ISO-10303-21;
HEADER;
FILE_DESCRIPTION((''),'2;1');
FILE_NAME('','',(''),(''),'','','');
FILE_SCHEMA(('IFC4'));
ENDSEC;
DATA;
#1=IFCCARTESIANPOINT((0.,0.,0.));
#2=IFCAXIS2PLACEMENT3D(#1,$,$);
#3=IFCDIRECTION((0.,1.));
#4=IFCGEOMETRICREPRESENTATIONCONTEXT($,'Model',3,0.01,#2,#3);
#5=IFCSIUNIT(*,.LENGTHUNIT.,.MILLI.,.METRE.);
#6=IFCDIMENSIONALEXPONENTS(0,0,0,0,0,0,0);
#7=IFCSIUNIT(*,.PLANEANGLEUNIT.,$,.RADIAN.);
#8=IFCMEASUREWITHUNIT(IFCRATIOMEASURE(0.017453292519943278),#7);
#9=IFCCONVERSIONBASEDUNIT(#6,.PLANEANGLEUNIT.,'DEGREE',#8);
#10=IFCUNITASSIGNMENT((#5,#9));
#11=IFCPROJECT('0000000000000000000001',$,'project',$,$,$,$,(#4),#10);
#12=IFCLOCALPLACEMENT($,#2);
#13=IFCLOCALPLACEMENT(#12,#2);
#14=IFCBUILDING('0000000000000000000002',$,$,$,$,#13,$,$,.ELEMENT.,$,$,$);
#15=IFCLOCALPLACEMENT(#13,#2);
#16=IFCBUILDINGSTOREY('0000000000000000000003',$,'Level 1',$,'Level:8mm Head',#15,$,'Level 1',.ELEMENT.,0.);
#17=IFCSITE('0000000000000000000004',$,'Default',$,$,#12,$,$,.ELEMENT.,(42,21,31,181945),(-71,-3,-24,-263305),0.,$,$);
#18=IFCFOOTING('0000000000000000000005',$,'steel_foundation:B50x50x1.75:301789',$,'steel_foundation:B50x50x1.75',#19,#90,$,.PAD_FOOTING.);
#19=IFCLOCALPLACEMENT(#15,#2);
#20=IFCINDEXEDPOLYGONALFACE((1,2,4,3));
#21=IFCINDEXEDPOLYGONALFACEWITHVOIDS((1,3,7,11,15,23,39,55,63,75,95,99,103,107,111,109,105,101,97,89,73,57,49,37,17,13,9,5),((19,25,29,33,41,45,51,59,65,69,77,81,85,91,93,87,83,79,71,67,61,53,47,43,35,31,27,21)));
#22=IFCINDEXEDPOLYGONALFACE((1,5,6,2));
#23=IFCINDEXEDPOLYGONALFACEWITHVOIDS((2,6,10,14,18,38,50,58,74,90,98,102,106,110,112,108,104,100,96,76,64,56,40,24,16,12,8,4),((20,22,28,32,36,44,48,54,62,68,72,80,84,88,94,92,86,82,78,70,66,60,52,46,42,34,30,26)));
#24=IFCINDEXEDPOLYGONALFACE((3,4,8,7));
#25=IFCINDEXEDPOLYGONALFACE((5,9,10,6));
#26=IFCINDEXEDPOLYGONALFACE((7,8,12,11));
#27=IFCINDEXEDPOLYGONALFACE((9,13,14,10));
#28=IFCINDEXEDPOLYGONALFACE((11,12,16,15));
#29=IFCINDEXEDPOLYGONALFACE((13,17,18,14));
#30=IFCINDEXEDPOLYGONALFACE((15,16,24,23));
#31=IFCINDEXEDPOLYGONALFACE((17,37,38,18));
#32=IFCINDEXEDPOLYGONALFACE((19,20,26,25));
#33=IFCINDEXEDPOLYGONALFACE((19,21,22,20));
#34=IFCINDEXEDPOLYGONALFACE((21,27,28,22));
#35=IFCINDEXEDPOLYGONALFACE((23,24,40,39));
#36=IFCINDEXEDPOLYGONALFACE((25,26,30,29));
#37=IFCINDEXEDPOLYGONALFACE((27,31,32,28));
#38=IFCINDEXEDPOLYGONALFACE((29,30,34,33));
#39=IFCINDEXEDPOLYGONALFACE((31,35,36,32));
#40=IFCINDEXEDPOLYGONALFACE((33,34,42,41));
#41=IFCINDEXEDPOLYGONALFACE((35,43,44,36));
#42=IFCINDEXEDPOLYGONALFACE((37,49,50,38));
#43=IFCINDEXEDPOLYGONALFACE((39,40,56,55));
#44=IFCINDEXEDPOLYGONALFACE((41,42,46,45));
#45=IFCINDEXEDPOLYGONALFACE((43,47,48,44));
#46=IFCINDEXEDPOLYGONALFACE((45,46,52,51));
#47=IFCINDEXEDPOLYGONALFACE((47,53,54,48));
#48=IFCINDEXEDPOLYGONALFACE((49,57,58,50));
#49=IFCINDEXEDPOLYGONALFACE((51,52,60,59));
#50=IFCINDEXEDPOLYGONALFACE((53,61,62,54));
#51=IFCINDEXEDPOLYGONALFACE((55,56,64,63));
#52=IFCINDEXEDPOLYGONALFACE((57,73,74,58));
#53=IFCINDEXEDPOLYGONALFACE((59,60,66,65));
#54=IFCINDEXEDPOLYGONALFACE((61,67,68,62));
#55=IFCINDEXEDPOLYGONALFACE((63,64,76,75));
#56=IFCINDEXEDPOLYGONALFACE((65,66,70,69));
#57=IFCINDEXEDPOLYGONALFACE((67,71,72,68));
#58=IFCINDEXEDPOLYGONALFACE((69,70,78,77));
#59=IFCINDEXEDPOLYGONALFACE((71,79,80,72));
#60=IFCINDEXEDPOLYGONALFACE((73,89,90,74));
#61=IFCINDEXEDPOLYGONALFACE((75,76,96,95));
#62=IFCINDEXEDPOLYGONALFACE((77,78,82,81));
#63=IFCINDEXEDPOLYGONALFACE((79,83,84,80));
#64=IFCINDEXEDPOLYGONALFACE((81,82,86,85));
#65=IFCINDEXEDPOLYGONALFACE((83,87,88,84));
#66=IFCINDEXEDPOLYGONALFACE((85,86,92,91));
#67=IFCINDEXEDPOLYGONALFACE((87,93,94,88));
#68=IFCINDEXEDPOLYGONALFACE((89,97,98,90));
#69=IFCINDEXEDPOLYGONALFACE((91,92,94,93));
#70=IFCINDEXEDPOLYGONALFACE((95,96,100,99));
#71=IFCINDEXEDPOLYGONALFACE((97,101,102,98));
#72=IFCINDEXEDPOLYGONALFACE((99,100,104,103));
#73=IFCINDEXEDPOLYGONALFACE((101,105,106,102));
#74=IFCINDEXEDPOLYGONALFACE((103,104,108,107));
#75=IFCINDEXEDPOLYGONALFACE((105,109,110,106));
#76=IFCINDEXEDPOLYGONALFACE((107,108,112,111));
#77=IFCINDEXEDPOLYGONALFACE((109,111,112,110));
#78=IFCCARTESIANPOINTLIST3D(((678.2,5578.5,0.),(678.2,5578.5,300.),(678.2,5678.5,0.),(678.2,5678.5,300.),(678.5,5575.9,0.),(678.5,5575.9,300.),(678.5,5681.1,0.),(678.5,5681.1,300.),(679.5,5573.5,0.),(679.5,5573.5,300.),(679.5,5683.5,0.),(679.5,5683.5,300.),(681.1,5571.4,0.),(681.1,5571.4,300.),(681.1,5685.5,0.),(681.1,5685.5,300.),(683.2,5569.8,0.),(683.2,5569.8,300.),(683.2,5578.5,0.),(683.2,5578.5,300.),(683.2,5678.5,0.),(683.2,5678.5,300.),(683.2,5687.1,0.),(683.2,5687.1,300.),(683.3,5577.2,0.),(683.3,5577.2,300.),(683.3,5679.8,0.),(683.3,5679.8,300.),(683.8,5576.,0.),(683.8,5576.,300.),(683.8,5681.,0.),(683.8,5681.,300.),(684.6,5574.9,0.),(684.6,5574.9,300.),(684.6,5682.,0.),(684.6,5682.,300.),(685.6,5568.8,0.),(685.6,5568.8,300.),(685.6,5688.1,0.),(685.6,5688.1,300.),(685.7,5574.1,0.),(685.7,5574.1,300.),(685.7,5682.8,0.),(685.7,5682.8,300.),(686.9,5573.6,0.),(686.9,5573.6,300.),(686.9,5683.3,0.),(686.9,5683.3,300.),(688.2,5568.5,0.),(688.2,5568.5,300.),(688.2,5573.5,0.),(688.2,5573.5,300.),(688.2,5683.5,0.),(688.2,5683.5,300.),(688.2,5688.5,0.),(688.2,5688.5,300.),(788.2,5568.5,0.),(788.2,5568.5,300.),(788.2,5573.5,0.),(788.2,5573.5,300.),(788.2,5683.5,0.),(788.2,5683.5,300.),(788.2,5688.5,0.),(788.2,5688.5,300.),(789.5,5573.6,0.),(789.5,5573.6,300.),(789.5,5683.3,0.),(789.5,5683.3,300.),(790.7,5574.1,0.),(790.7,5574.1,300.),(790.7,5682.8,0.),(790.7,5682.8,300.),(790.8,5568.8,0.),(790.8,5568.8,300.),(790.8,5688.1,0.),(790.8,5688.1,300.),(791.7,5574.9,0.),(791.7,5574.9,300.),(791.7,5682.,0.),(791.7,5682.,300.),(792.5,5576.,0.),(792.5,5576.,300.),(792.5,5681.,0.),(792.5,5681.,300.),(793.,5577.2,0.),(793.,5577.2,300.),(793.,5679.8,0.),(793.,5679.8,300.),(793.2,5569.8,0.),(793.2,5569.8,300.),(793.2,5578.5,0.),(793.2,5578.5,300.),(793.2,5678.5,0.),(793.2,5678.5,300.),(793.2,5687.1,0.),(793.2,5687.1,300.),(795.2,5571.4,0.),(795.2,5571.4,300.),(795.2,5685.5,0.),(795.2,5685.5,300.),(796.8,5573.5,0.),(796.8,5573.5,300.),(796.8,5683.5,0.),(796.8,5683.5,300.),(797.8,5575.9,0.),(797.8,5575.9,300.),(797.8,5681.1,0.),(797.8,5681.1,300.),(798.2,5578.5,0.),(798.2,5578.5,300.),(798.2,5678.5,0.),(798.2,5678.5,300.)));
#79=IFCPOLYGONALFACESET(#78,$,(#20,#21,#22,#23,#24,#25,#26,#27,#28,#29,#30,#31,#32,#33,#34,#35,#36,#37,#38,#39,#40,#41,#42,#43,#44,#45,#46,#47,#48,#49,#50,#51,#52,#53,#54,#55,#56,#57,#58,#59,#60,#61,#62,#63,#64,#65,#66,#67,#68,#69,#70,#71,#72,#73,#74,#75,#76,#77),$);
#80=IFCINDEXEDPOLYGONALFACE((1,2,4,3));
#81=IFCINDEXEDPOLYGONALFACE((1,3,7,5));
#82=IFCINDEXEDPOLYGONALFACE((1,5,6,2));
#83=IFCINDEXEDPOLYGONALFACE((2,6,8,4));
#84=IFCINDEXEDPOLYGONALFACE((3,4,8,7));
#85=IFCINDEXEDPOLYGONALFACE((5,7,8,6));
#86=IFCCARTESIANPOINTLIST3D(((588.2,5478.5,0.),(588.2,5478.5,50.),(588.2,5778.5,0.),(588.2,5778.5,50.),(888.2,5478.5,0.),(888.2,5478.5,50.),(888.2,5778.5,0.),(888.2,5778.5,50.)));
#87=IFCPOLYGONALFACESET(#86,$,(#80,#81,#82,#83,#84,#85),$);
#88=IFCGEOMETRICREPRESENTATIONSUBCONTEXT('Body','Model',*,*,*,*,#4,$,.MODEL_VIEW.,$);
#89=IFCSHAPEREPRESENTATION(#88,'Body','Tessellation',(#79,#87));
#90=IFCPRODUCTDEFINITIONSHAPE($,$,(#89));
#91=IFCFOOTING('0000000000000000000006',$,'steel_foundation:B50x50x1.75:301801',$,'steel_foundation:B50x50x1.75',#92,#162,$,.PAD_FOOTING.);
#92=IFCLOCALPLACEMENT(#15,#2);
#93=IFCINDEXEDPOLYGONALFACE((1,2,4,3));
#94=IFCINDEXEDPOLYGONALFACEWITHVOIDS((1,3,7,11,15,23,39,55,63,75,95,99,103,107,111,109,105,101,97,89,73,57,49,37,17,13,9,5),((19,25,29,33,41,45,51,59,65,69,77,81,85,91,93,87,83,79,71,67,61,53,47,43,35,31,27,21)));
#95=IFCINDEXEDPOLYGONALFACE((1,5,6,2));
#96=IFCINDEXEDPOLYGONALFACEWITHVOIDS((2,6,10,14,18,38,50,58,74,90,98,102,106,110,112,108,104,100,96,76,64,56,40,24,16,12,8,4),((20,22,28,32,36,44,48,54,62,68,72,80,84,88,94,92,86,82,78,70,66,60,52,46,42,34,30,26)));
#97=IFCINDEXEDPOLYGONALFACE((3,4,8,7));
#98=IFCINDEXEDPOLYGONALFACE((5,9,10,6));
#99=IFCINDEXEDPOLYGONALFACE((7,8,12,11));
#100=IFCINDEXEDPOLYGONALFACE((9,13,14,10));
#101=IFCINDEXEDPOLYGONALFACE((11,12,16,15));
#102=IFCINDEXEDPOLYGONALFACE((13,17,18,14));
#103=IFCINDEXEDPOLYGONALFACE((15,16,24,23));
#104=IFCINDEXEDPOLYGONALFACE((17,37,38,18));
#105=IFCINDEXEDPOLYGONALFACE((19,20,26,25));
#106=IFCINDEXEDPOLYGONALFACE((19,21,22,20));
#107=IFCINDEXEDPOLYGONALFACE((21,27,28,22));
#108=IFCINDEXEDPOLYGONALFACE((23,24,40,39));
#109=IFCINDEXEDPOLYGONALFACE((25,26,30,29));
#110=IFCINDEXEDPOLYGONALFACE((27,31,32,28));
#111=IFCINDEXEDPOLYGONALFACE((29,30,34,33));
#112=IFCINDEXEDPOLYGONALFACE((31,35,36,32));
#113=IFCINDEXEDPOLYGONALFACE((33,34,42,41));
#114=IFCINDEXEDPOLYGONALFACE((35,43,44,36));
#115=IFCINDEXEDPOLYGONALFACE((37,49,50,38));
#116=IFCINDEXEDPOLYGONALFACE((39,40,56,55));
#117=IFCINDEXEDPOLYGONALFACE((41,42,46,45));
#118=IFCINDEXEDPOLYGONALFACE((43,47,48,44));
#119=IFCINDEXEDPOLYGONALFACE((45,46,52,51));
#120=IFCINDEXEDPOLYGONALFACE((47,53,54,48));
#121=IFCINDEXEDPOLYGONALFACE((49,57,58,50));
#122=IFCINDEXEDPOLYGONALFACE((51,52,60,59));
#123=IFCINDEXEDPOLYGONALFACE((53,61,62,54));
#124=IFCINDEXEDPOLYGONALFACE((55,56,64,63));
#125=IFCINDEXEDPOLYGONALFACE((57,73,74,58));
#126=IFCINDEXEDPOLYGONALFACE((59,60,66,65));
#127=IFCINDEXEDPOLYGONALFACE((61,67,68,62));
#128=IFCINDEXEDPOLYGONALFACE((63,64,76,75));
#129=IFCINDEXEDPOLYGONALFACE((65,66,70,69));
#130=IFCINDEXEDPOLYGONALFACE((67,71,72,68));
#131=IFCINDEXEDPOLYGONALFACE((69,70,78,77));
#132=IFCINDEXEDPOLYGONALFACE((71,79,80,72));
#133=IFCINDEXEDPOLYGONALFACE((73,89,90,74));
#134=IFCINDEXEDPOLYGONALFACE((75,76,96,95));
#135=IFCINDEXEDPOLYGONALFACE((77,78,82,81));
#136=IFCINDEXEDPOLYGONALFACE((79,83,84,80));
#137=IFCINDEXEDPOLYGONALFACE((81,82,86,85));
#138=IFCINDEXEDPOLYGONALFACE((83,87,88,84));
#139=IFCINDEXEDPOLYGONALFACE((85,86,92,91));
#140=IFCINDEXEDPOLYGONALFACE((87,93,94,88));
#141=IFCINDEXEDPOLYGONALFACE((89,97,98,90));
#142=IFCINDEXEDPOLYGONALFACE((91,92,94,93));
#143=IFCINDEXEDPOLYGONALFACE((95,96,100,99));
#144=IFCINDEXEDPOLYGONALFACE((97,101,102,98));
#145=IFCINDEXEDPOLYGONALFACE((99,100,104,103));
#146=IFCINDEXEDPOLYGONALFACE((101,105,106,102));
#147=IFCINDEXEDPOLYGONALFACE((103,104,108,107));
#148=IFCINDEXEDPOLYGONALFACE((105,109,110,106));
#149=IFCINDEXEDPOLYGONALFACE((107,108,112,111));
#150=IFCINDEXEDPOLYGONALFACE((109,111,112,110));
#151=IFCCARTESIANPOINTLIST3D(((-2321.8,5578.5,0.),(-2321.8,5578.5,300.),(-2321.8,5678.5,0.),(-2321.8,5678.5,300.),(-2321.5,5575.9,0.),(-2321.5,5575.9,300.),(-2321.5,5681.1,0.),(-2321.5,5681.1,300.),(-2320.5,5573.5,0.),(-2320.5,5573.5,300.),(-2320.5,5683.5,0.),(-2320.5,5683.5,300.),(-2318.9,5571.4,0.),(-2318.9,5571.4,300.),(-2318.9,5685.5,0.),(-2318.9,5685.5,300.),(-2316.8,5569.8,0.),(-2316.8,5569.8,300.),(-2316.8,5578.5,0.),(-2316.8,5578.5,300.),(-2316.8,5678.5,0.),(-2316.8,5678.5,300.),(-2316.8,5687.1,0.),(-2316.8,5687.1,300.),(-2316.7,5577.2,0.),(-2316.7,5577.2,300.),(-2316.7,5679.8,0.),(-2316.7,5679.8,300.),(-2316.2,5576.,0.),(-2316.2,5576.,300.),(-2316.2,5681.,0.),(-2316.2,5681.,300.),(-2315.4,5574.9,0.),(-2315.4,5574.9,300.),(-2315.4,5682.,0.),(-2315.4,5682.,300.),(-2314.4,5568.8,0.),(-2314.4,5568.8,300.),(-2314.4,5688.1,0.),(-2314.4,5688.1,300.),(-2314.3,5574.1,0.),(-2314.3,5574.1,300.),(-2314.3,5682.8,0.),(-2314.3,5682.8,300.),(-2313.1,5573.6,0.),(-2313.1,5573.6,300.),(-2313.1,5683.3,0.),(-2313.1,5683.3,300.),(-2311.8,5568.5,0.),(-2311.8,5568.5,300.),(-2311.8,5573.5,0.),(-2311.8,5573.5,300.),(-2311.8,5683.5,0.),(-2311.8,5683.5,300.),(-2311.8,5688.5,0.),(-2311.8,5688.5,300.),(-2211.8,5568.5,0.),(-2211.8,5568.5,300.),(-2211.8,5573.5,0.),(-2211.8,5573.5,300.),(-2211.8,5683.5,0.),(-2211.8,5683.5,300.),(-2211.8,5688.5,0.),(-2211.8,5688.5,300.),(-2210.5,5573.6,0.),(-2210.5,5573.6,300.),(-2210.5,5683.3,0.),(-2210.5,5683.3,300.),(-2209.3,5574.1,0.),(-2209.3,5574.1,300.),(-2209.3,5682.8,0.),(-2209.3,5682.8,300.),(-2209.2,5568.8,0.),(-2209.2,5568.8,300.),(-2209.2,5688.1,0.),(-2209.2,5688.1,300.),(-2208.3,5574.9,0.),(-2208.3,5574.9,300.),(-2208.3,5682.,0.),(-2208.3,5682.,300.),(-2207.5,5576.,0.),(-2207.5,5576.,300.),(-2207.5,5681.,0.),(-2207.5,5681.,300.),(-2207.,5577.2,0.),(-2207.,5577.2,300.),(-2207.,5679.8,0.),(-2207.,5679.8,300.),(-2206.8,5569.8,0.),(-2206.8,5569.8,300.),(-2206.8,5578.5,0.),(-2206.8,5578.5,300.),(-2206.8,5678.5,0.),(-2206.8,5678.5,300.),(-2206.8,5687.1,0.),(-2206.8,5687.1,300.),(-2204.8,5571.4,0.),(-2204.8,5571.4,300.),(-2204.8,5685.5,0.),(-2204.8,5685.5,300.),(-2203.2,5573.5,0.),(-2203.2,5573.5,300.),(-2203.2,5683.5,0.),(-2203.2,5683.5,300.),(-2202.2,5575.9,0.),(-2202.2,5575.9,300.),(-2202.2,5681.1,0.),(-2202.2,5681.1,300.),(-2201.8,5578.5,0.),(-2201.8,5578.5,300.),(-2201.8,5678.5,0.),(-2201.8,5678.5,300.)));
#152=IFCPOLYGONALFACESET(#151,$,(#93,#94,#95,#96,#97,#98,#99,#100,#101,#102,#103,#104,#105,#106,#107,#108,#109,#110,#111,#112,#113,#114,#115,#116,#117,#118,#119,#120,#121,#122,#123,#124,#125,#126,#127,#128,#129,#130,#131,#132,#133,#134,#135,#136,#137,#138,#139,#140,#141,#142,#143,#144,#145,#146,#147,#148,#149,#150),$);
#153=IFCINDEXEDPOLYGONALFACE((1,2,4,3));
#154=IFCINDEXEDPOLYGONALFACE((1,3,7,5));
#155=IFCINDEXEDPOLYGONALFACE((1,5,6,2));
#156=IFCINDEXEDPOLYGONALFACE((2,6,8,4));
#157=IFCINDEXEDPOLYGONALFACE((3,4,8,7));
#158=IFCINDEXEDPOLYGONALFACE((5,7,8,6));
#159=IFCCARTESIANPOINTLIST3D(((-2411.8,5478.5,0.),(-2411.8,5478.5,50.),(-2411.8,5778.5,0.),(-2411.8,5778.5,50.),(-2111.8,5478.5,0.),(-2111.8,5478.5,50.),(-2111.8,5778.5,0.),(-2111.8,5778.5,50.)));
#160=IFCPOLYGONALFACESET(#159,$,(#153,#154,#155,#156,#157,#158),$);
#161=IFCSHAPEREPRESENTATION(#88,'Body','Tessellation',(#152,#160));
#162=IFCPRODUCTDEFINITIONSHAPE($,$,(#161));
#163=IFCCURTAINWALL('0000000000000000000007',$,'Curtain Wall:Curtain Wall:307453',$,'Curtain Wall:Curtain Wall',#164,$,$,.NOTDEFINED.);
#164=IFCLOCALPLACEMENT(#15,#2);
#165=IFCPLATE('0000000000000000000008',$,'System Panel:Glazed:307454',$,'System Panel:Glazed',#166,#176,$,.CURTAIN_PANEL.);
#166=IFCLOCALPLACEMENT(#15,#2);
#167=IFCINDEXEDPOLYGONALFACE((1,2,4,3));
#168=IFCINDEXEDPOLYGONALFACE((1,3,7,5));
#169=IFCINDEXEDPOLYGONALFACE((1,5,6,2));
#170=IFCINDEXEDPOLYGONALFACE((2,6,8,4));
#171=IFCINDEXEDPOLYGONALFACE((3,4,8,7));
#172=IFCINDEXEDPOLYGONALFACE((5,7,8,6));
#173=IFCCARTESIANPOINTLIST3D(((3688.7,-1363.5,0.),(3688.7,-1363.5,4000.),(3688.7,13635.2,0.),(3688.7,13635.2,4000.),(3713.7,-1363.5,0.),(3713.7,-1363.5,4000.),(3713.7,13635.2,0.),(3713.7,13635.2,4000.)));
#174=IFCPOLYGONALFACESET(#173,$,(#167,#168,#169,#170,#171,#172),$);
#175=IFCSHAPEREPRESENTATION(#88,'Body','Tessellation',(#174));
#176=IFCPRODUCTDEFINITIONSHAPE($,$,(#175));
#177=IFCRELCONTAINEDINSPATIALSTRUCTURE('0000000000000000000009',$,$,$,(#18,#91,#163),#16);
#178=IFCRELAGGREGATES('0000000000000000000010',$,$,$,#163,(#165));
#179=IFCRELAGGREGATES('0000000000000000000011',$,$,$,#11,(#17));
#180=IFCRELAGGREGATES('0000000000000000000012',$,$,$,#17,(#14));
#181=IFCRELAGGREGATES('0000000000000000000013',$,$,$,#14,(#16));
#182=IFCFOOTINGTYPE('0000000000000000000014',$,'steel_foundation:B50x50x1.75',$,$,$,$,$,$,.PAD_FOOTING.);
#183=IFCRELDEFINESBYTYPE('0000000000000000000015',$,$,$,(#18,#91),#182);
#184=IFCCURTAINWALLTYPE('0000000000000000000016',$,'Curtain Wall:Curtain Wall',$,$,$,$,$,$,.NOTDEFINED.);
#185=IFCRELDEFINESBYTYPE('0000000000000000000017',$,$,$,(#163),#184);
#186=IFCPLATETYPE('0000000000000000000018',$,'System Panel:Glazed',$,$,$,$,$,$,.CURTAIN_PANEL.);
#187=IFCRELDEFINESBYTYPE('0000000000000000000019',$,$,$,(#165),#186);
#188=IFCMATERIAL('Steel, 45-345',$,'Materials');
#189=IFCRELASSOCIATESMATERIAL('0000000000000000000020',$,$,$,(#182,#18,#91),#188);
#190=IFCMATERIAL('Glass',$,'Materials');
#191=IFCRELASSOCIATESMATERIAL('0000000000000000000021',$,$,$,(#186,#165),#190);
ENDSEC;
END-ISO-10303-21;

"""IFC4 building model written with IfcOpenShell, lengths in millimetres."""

from ifc_helpers import new_model, entity, si_unit, converted_unit, direction, frame, frame_2d, origin, origin_2d_with_axis, place, context, subcontext, project, spatial, polyline, circle_curve, parameter, trimmed, segment, composite_curve, rectangle, outline, extrude, source, transform, mapped, material, type_object, type_shapes, element, aggregate, save


model = new_model("IFC4")

# Units and contexts
model_context = context("Model", 3, precision=0.01, world=origin(), true_north=direction((0.0, 1.0)))
body_context = subcontext(model_context, "Body", "Model", "MODEL_VIEW")
ifc_project = project(units=[si_unit("LENGTHUNIT", "METRE", prefix="MILLI"), converted_unit("PLANEANGLEUNIT", "DEGREE", entity("IfcRatioMeasure", 0.017453292519943278), si_unit("PLANEANGLEUNIT", "RADIAN"), dimensions=[0, 0, 0, 0, 0, 0, 0])], contexts=[model_context])

# Site, building, storey
site_placement = place(None, origin())
site = spatial("IfcSite", under=ifc_project, at=site_placement, Name="Default", CompositionType="ELEMENT", RefLatitude=(42, 21, 31, 181945), RefLongitude=(-71, -3, -24, -263305), RefElevation=0.0)
building_placement = place(site_placement, origin())
building = spatial("IfcBuilding", under=site, at=building_placement, CompositionType="ELEMENT")
storey_placement = place(building_placement, origin())
storey = spatial("IfcBuildingStorey", under=building, at=storey_placement, Name="Level 1", ObjectType="Level:8mm Head", LongName="Level 1", CompositionType="ELEMENT", Elevation=0.0)

# Footings
ifc_material_1 = material(Name="Steel, 45-345", Category="Materials")
footing_type = type_object("IfcFootingType", Name="steel_foundation:B50x50x1.75", PredefinedType="PAD_FOOTING", material=ifc_material_1)
shared_shape_1 = source(origin(), body_context, "Body", "SweptSolid", [
    extrude(outline(composite_curve([segment(polyline([(-50.0, -60.0), (50.0, -60.0)]), True, "CONTINUOUS"), segment(trimmed(circle_curve(frame_2d((50.0, -50.0), x_axis=(-1.0, 0.0)), 10.0), [parameter(90.0)], [parameter(180.0)], True, "PARAMETER"), True, "CONTINUOUS"), segment(polyline([(60.0, -50.0), (60.0, 50.0)]), True, "CONTINUOUS"), segment(trimmed(circle_curve(frame_2d((50.0, 50.0), x_axis=(-1.0, 0.0)), 10.0), [parameter(180.0)], [parameter(270.0)], True, "PARAMETER"), True, "CONTINUOUS"), segment(polyline([(50.0, 60.0), (-50.0, 60.0)]), True, "CONTINUOUS"), segment(trimmed(circle_curve(frame_2d((-50.0, 50.0), x_axis=(-1.0, 0.0)), 10.0), [parameter(270.0)], [parameter(360.0)], True, "PARAMETER"), True, "CONTINUOUS"), segment(polyline([(-60.0, 50.0), (-60.0, -50.0)]), True, "CONTINUOUS"), segment(trimmed(circle_curve(frame_2d((-50.0, -50.0), x_axis=(-1.0, 0.0)), 10.0), [parameter(360.0)], [parameter(90.0)], True, "PARAMETER"), True, "CONTINUOUS")], self_intersect=False), holes=[composite_curve([segment(trimmed(circle_curve(frame_2d((-50.0, -50.0), x_axis=(-1.0, 0.0)), 5.0), [parameter(0.0)], [parameter(90.0)], True, "PARAMETER"), False, "CONTINUOUS"), segment(polyline([(-55.0, -50.0), (-55.0, 50.0)]), True, "CONTINUOUS"), segment(trimmed(circle_curve(frame_2d((-50.0, 50.0), x_axis=(-1.0, 0.0)), 5.0), [parameter(270.0)], [parameter(360.0)], True, "PARAMETER"), False, "CONTINUOUS"), segment(polyline([(-50.0, 55.0), (50.0, 55.0)]), True, "CONTINUOUS"), segment(trimmed(circle_curve(frame_2d((50.0, 50.0), x_axis=(-1.0, 0.0)), 5.0), [parameter(180.0)], [parameter(270.0)], True, "PARAMETER"), False, "CONTINUOUS"), segment(polyline([(55.0, 50.0), (55.0, -50.0)]), True, "CONTINUOUS"), segment(trimmed(circle_curve(frame_2d((50.0, -50.0), x_axis=(-1.0, 0.0)), 5.0), [parameter(90.0)], [parameter(180.0)], True, "PARAMETER"), False, "CONTINUOUS"), segment(polyline([(50.0, -55.0), (-50.0, -55.0)]), True, "CONTINUOUS")], self_intersect=False)]), frame((0.0, 0.0, 0.0), z_axis=(0.0, 0.0, 1.0), x_axis=(-1.0, 0.0, 0.0)), (0.0, 0.0, 1.0), 300.0),
    extrude(rectangle(XDim=300.0, YDim=300.0, at=frame_2d((0.0, 0.0), x_axis=(1.0, 0.0))), frame((0.0, 0.0, 0.0), z_axis=(0.0, 0.0, 1.0), x_axis=(-1.0, 0.0, 0.0)), (0.0, 0.0, 1.0), 50.0),
])
type_shapes(footing_type, [shared_shape_1])
for number, where, name in (
    (1, (738.2, 5628.5, 0.0), "steel_foundation:B50x50x1.75:301789"),
    (2, (-2261.8, 5628.5, 0.0), "steel_foundation:B50x50x1.75:301801"),
):
    element("IfcFooting", number, at=place(storey_placement, frame(where)), inside=storey, type_object=footing_type, material=ifc_material_1, Name=name, ObjectType="steel_foundation:B50x50x1.75", PredefinedType="PAD_FOOTING", context=body_context, shape_type="MappedRepresentation", body=[
        mapped(shared_shape_1, transform((0.0, 0.0, 0.0), scale=1.0)),
    ])

# Curtain wall, plate
curtain_wall_type = type_object("IfcCurtainWallType", Name="Curtain Wall:Curtain Wall", PredefinedType="NOTDEFINED")
curtain_wall_1_placement = place(storey_placement, origin())
curtain_wall_1 = element("IfcCurtainWall", 3, at=curtain_wall_1_placement, inside=storey, type_object=curtain_wall_type, Name="Curtain Wall:Curtain Wall:307453", ObjectType="Curtain Wall:Curtain Wall", PredefinedType="NOTDEFINED")
ifc_material_2 = material(Name="Glass", Category="Materials")
plate_type_1 = type_object("IfcPlateType", Name="System Panel:Glazed", PredefinedType="CURTAIN_PANEL", material=ifc_material_2)
shared_shape_2 = source(origin(), body_context, "Body", "SweptSolid", [
    extrude(rectangle(XDim=25.0, YDim=14998.7, at=origin_2d_with_axis()), frame((7499.3, 12.5, 0.0), z_axis=(0.0, 0.0, 1.0), x_axis=(0.0, 1.0, 0.0)), (0.0, 0.0, 1.0), 4000.0),
])
type_shapes(plate_type_1, [shared_shape_2])
plate_1_placement = place(curtain_wall_1_placement, frame((3713.7, -1363.5, 0.0), z_axis=(0.0, 0.0, 1.0), x_axis=(0.0, 1.0, 0.0)))
plate_1 = element("IfcPlate", 4, at=plate_1_placement, type_object=plate_type_1, material=ifc_material_2, Name="System Panel:Glazed:307454", ObjectType="System Panel:Glazed", PredefinedType="CURTAIN_PANEL", context=body_context, shape_type="MappedRepresentation", body=[
    mapped(shared_shape_2, transform((0.0, 0.0, 0.0), scale=1.0)),
])
aggregate(curtain_wall_1, [plate_1])

save(model, "model.ifc")
